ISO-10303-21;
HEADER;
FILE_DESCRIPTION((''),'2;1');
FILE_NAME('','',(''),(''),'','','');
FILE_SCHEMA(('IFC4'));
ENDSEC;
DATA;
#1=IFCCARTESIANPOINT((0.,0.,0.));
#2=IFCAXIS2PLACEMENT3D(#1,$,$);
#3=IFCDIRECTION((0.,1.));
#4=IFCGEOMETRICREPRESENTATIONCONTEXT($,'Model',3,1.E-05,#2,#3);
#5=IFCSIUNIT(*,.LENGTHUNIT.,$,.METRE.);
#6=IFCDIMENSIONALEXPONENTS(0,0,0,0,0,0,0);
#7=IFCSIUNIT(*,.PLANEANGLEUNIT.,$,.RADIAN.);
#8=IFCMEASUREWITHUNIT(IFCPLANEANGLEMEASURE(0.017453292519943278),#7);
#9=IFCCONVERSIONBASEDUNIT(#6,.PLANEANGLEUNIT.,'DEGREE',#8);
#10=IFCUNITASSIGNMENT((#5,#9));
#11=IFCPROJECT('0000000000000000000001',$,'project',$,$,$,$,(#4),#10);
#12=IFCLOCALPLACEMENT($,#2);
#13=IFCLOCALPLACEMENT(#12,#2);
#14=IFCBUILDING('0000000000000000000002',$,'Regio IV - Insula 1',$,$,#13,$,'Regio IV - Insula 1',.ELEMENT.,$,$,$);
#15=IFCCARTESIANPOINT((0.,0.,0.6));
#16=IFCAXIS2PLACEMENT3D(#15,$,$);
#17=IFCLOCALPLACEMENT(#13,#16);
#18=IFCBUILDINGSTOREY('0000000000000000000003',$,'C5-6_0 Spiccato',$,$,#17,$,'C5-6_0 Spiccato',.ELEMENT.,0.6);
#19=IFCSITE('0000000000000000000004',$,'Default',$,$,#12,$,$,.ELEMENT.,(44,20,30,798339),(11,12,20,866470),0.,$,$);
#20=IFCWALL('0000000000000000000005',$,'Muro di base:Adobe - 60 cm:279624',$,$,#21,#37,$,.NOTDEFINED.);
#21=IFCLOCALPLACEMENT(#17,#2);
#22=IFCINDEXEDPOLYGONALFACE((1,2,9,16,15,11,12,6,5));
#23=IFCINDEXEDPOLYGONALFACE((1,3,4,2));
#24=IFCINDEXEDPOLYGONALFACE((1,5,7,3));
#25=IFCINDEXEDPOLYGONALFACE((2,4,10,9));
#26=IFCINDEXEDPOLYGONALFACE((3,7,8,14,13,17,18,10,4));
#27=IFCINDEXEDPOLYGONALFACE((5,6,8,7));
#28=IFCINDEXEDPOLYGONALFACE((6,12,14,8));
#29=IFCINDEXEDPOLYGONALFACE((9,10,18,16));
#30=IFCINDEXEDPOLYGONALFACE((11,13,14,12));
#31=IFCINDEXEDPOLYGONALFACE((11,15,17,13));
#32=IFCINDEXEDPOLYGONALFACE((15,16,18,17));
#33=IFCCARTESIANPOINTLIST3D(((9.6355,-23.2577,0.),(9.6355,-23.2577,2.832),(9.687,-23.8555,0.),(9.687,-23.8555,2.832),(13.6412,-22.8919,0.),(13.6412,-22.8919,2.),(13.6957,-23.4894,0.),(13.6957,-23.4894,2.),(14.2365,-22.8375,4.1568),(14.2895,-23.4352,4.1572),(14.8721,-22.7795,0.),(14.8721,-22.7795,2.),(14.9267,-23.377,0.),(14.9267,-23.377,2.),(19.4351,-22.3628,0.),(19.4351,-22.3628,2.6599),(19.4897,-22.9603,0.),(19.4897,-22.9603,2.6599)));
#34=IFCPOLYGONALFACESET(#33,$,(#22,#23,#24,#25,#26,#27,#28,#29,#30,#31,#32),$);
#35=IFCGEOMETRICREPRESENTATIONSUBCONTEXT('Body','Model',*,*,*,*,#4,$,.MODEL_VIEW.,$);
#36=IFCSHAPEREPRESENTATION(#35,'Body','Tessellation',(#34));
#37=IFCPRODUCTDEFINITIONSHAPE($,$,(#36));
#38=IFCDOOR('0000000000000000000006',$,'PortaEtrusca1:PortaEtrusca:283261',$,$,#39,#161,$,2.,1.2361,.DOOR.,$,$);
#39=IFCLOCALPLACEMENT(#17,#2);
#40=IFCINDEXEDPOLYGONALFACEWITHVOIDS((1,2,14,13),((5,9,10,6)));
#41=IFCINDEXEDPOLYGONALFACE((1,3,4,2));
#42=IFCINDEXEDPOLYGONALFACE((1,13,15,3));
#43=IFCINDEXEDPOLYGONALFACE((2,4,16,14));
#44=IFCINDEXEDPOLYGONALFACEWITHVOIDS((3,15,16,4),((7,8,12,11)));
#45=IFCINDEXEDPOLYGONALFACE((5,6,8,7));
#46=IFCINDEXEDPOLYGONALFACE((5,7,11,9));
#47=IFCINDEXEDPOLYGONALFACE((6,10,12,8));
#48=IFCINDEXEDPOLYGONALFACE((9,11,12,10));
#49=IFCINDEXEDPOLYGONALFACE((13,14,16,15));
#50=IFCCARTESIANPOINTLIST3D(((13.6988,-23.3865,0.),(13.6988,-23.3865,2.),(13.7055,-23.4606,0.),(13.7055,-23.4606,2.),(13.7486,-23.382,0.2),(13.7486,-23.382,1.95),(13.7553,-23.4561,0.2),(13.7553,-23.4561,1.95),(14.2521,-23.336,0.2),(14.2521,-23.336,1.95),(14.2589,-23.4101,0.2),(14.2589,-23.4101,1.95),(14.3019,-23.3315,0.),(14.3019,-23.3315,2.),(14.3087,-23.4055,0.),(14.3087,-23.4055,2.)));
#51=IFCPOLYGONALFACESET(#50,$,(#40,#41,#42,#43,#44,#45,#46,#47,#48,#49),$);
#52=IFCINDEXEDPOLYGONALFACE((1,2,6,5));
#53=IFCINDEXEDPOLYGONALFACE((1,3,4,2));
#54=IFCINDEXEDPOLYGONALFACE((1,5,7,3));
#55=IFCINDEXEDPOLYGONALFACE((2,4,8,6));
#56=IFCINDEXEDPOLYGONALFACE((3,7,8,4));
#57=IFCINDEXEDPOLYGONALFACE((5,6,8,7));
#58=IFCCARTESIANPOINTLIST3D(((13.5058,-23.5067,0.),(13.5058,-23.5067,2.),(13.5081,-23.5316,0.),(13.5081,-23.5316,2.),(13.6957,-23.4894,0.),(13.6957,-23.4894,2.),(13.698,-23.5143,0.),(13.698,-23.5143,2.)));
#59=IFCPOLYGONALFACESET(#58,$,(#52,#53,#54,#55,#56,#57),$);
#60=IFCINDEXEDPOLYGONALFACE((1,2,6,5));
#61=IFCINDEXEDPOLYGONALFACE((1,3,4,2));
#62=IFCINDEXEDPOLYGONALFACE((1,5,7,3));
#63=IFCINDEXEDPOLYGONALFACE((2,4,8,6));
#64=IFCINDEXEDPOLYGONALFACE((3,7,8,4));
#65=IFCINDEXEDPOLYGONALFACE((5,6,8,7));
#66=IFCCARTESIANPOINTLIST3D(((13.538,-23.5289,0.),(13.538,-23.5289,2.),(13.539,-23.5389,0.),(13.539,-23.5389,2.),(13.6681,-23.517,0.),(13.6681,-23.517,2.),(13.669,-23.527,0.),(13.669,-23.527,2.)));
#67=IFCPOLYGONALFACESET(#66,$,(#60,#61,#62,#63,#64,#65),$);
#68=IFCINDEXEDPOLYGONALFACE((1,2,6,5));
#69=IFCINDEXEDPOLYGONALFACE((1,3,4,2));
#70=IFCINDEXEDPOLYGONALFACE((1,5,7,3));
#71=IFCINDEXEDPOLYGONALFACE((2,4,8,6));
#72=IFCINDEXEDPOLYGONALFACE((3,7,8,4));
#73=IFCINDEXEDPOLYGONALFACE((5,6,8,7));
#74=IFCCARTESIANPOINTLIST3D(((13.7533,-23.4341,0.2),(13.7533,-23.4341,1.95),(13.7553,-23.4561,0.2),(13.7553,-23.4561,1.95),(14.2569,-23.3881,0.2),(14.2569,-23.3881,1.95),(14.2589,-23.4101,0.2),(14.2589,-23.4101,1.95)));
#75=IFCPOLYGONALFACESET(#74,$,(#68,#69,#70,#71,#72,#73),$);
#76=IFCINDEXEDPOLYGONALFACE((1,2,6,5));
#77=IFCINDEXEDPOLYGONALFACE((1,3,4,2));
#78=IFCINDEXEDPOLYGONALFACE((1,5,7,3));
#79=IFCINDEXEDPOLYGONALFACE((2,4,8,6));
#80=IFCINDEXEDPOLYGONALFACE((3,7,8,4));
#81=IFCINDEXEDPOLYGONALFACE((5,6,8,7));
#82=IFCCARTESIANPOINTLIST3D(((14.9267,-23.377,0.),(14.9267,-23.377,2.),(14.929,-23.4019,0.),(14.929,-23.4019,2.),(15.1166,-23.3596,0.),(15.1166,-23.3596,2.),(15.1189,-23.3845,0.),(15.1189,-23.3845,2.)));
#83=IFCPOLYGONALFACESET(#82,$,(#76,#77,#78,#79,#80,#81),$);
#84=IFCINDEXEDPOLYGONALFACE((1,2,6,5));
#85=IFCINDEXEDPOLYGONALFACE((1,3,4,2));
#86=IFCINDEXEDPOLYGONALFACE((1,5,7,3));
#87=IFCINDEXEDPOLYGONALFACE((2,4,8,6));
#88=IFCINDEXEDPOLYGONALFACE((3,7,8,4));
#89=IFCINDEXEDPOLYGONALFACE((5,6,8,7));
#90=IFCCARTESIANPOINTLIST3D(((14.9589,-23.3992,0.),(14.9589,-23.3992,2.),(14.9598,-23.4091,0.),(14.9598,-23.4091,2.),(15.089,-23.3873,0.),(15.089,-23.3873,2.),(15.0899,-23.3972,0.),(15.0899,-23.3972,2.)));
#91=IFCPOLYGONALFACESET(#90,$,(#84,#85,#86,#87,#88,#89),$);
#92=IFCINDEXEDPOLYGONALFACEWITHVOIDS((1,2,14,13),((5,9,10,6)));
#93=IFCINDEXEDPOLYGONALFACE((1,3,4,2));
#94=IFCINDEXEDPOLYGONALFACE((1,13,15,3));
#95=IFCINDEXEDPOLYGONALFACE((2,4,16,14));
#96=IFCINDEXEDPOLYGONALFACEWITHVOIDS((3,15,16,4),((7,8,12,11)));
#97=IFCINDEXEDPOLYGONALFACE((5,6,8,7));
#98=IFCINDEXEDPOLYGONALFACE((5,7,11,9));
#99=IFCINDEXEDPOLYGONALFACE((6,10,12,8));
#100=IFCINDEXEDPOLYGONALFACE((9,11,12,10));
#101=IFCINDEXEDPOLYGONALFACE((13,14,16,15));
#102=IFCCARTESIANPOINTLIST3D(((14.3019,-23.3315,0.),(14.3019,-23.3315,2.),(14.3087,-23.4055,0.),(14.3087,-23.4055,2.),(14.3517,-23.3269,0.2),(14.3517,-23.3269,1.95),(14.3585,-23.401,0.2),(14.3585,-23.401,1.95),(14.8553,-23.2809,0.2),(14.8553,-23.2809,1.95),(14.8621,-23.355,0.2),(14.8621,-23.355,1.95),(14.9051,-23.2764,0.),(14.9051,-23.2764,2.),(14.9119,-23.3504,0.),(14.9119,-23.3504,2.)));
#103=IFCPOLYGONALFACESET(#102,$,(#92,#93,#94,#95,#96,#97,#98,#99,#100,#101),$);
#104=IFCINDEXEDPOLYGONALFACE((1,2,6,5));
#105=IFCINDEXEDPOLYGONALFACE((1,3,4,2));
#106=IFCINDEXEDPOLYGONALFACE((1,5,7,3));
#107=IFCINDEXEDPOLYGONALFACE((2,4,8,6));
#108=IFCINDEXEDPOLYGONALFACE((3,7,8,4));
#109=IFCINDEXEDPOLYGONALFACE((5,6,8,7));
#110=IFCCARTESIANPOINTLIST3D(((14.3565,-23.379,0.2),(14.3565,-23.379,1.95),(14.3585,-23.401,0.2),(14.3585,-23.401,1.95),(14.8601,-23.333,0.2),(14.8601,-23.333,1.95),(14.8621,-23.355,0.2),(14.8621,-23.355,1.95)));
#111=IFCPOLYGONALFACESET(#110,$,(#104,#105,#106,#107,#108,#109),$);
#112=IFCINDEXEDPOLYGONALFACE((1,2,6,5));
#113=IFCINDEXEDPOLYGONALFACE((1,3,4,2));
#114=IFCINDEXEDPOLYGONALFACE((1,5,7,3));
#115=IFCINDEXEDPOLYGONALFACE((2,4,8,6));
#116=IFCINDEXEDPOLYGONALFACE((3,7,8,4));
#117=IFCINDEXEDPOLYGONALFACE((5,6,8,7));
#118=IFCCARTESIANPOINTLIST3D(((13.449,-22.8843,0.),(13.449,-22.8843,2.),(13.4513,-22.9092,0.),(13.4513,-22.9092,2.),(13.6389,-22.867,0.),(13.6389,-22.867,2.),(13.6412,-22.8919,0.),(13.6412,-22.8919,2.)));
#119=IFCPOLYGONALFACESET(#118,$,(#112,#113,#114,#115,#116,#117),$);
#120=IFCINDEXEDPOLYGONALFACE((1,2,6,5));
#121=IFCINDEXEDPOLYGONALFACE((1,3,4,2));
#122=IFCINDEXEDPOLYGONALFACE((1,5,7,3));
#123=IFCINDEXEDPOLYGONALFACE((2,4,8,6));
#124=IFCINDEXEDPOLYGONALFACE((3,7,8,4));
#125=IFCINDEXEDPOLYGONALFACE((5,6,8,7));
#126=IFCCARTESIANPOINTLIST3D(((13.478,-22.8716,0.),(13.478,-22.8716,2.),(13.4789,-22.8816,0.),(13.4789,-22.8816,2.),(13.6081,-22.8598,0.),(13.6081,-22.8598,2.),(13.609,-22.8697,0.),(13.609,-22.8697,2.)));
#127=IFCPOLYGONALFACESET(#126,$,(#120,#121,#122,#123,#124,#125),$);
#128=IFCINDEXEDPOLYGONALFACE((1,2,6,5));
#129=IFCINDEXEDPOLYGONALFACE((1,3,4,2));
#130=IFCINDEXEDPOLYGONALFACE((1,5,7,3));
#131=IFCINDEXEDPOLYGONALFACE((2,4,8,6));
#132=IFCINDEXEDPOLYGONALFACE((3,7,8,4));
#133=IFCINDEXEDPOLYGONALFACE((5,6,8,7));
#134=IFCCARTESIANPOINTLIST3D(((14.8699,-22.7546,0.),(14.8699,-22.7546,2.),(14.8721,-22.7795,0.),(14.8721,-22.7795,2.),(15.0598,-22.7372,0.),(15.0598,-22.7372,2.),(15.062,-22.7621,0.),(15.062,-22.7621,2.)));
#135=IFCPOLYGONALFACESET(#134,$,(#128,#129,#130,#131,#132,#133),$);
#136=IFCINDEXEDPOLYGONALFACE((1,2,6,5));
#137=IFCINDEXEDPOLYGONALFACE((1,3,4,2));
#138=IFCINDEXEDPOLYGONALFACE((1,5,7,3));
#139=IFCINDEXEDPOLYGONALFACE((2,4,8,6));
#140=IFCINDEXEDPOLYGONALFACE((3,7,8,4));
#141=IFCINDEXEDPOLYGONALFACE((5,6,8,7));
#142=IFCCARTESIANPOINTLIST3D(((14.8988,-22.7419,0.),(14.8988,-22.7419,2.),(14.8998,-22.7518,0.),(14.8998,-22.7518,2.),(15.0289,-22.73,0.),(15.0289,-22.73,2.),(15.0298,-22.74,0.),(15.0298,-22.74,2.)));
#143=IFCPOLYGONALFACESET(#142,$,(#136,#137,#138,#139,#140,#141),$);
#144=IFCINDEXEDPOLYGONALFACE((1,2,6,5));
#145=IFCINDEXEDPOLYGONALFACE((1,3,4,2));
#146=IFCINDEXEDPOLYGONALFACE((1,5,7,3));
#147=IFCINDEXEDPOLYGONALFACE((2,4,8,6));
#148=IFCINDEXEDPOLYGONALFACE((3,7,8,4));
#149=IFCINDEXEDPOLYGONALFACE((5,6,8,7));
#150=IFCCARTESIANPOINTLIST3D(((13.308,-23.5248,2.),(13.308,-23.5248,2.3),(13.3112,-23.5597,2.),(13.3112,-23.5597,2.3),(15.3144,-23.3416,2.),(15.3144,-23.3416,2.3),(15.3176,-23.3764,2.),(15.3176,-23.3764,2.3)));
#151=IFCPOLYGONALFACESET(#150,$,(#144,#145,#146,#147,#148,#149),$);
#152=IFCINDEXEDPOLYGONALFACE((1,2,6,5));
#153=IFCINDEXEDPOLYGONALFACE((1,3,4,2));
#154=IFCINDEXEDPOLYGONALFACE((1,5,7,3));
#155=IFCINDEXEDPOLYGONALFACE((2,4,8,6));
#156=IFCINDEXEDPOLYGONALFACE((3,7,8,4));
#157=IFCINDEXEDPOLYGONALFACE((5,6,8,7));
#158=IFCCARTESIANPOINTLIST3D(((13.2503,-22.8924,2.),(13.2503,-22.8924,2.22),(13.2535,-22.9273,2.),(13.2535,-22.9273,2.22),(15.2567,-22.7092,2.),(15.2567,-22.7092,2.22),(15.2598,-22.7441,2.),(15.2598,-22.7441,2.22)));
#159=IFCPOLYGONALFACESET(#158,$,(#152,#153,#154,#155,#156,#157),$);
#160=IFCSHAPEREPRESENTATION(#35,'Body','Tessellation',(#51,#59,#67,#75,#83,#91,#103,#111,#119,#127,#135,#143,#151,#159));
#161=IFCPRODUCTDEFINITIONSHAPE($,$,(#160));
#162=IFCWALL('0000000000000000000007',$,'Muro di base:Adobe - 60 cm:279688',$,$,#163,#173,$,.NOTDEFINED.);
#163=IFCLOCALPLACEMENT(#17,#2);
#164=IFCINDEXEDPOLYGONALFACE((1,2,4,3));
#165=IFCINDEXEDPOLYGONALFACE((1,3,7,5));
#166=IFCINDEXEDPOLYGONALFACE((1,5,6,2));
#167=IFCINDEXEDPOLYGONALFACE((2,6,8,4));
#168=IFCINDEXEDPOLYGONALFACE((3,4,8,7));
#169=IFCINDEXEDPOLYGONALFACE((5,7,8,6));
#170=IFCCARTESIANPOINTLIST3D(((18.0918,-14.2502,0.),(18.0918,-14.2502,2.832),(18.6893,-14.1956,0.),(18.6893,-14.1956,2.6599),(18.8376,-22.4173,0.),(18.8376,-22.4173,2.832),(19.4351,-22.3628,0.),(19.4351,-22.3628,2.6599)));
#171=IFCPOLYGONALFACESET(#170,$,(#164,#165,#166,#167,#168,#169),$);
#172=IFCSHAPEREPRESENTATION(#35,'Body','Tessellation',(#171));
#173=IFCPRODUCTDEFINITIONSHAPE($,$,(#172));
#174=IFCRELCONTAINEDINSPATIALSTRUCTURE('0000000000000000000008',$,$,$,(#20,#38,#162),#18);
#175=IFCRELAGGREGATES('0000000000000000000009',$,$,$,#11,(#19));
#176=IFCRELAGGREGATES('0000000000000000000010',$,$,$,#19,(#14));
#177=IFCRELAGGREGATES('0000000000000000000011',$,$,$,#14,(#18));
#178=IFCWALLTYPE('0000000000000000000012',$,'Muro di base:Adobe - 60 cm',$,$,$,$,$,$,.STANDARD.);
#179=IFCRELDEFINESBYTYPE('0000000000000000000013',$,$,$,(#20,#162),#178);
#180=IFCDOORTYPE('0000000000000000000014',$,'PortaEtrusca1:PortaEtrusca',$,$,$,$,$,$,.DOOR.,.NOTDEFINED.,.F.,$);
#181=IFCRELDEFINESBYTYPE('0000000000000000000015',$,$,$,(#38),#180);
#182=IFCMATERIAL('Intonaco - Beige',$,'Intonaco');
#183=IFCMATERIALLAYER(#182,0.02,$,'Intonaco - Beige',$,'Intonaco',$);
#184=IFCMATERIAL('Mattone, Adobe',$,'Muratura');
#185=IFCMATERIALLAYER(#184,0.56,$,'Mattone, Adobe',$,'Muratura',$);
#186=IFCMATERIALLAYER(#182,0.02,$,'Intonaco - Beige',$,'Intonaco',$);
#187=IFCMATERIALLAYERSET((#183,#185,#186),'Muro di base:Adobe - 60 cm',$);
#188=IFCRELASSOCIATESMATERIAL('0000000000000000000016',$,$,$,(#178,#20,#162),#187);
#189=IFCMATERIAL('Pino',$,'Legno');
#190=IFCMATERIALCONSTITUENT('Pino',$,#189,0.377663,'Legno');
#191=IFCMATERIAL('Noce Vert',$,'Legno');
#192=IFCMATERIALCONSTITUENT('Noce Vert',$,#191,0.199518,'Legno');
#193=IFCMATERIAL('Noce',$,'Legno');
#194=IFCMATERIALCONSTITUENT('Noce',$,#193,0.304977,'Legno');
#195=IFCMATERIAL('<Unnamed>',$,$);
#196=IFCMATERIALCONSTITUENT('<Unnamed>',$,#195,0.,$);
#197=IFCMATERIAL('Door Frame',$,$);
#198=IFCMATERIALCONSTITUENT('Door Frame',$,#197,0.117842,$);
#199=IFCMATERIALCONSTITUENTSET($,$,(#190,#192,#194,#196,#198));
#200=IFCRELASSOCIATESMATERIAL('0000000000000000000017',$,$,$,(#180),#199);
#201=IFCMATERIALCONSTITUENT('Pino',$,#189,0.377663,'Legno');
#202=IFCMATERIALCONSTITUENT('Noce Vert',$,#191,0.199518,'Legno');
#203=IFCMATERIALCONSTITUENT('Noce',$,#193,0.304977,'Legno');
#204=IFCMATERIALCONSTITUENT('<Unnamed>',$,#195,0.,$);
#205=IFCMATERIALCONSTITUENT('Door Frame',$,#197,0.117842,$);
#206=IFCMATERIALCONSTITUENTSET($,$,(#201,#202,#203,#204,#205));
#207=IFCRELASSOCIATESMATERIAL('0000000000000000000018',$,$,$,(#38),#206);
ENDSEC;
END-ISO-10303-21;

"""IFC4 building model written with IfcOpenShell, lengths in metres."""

from ifc_helpers import new_model, entity, si_unit, converted_unit, direction, frame, frame_2d, origin, origin_2d_with_axis, place, context, subcontext, project, spatial, polyline, rectangle, outline, extrude, clip, bounded_halfspace, source, transform, mapped, material, layer, layer_set, layer_usage, constituent, constituent_set, type_object, type_shapes, element, fill, save


model = new_model("IFC4")

# Units and contexts
model_context = context("Model", 3, precision=1e-05, world=origin(), true_north=direction((0.0, 1.0)))
body_context = subcontext(model_context, "Body", "Model", "MODEL_VIEW")
ifc_project = project(units=[si_unit("LENGTHUNIT", "METRE"), converted_unit("PLANEANGLEUNIT", "DEGREE", entity("IfcPlaneAngleMeasure", 0.017453292519943278), si_unit("PLANEANGLEUNIT", "RADIAN"), dimensions=[0, 0, 0, 0, 0, 0, 0])], contexts=[model_context])

# Site, building, storey
site_placement = place(None, origin())
site = spatial("IfcSite", under=ifc_project, at=site_placement, Name="Default", CompositionType="ELEMENT", RefLatitude=(44, 20, 30, 798339), RefLongitude=(11, 12, 20, 866470), RefElevation=0.0)
building_placement = place(site_placement, origin())
building = spatial("IfcBuilding", under=site, at=building_placement, Name="Regio IV - Insula 1", LongName="Regio IV - Insula 1", CompositionType="ELEMENT")
storey_placement = place(building_placement, frame((0.0, 0.0, 0.6)))
storey = spatial("IfcBuildingStorey", under=building, at=storey_placement, Name="C5-6_0 Spiccato", LongName="C5-6_0 Spiccato", CompositionType="ELEMENT", Elevation=0.6)

# Shared definitions
ifc_material_1 = material(Name="Intonaco - Beige", Category="Intonaco")
ifc_layer_1 = layer(ifc_material_1, 0.02, Name="Intonaco - Beige", Category="Intonaco")
ifc_material_2 = material(Name="Mattone, Adobe", Category="Muratura")
ifc_layer_2 = layer(ifc_material_2, 0.56, Name="Mattone, Adobe", Category="Muratura")
ifc_layer_3 = layer(ifc_material_1, 0.02, Name="Intonaco - Beige", Category="Intonaco")
ifc_layer_set_1 = layer_set([ifc_layer_1, ifc_layer_2, ifc_layer_3], Name="Muro di base:Adobe - 60 cm")
wall_type_1 = type_object("IfcWallType", Name="Muro di base:Adobe - 60 cm", PredefinedType="STANDARD", material=ifc_layer_set_1)

# Wall, opening, door
ifc_layer_usage_1 = layer_usage(ifc_layer_set_1, "AXIS2", "NEGATIVE", 0.3)
wall_1_placement = place(storey_placement, frame((9.6597, -23.5567, 0.0), z_axis=(0.0, 0.0, 1.0), x_axis=(0.995856, 0.090941, 0.0)))
wall_1 = element("IfcWall", 1, at=wall_1_placement, inside=storey, type_object=wall_type_1, material=ifc_layer_usage_1, Name="Muro di base:Adobe - 60 cm:279624", PredefinedType="NOTDEFINED", context=body_context, shape_type="Clipping", body=[
    clip(clip(extrude(outline(polyline([(0.0, -0.3), (9.8434, -0.3), (9.8434, 0.3), (0.0031, 0.3), (0.0, -0.3)])), origin(), (0.0, 0.0, 1.0), 4.1572), bounded_halfspace(frame((9.8434, -0.3, 2.6599), z_axis=(0.275637, 0.0, 0.961262), x_axis=(0.0, 1.0, 0.0)), False, frame((9.8434, -0.3, 2.6599)), polyline([(0.0, 0.0), (0.0, 0.6), (-0.6, 0.6), (-5.2203, 0.6), (-5.2218, 0.0), (0.0, 0.0)]))), bounded_halfspace(frame((0.0031, 0.3, 2.832), z_axis=(-0.275634, 0.001422, 0.961262), x_axis=(-0.00516, -0.999987, 0.0)), False, frame((0.0031, 0.3, 2.832)), polyline([(0.0, 0.0), (-0.0031, -0.6), (4.6185, -0.6), (4.6201, 0.0), (0.0, 0.0)]))),
])
opening_1_placement = place(wall_1_placement, frame((4.0254, -0.3, 0.0)))
opening_1 = element("IfcOpeningElement", 2, at=opening_1_placement, cuts=wall_1, PredefinedType="OPENING", context=body_context, shape_type="SweptSolid", body=[
    extrude(rectangle(XDim=2.0, YDim=1.2361, at=frame_2d((1.0, 0.618), x_axis=(1.0, 0.0))), frame((0.0, 0.0, 0.0), z_axis=(0.0, 1.0, 0.0), x_axis=(0.0, 0.0, 1.0)), (0.0, 0.0, 1.0), 0.6),
])
ifc_material_3 = material(Name="Pino", Category="Legno")
ifc_constituent_1 = constituent(ifc_material_3, Name="Pino", Category="Legno", fraction=0.377663)
ifc_material_4 = material(Name="Noce Vert", Category="Legno")
ifc_constituent_2 = constituent(ifc_material_4, Name="Noce Vert", Category="Legno", fraction=0.199518)
ifc_material_5 = material(Name="Noce", Category="Legno")
ifc_constituent_3 = constituent(ifc_material_5, Name="Noce", Category="Legno", fraction=0.304977)
ifc_material_6 = material(Name="<Unnamed>")
ifc_constituent_4 = constituent(ifc_material_6, Name="<Unnamed>", fraction=0.0)
ifc_material_7 = material(Name="Door Frame")
ifc_constituent_5 = constituent(ifc_material_7, Name="Door Frame", fraction=0.117842)
ifc_constituent_set_1 = constituent_set(constituents=[ifc_constituent_1, ifc_constituent_2, ifc_constituent_3, ifc_constituent_4, ifc_constituent_5])
ifc_constituent_6 = constituent(ifc_material_3, Name="Pino", Category="Legno", fraction=0.377663)
ifc_constituent_7 = constituent(ifc_material_4, Name="Noce Vert", Category="Legno", fraction=0.199518)
ifc_constituent_8 = constituent(ifc_material_5, Name="Noce", Category="Legno", fraction=0.304977)
ifc_constituent_9 = constituent(ifc_material_6, Name="<Unnamed>", fraction=0.0)
ifc_constituent_10 = constituent(ifc_material_7, Name="Door Frame", fraction=0.117842)
ifc_constituent_set_2 = constituent_set(constituents=[ifc_constituent_6, ifc_constituent_7, ifc_constituent_8, ifc_constituent_9, ifc_constituent_10])
door_type_1 = type_object("IfcDoorType", Name="PortaEtrusca1:PortaEtrusca", OperationType="NOTDEFINED", ParameterTakesPrecedence=False, PredefinedType="DOOR", material=ifc_constituent_set_2)
shared_shape_1 = source(origin(), body_context, "Body", "SweptSolid", [
    extrude(outline(polyline([(-1.0, -0.3028), (1.0, -0.3028), (1.0, 0.3028), (-1.0, 0.3028), (-1.0, -0.3028)]), holes=[polyline([(-0.95, 0.2528), (0.8, 0.2528), (0.8, -0.2528), (-0.95, -0.2528), (-0.95, 0.2528)])]), frame((0.3152, 0.0278, 1.0), z_axis=(0.0, 1.0, 0.0), x_axis=(0.0, 0.0, -1.0)), (0.0, 0.0, 1.0), 0.0744),
    extrude(rectangle(XDim=0.025, YDim=0.1907, at=frame_2d((0.0, 0.0), x_axis=(1.0, 0.0))), frame((-0.0953, -0.0125, 0.0), z_axis=(0.0, 0.0, 1.0), x_axis=(0.0, 1.0, 0.0)), (0.0, 0.0, 1.0), 2.0),
    extrude(rectangle(XDim=0.01, YDim=0.1306, at=frame_2d((0.0, 0.0), x_axis=(1.0, 0.0))), frame((-0.0953, -0.03, 0.0), z_axis=(0.0, 0.0, 1.0), x_axis=(0.0, 1.0, 0.0)), (0.0, 0.0, 1.0), 2.0),
    extrude(rectangle(XDim=0.0221, YDim=0.5057, at=frame_2d((0.0, 0.0), x_axis=(1.0, 0.0))), frame((0.3152, 0.0388, 0.2), z_axis=(0.0, 0.0, 1.0), x_axis=(0.0, 1.0, 0.0)), (0.0, 0.0, 1.0), 1.75),
    extrude(rectangle(XDim=0.025, YDim=0.1907, at=frame_2d((0.0, 0.0), x_axis=(1.0, 0.0))), frame((1.3314, -0.0125, 0.0), z_axis=(0.0, 0.0, 1.0), x_axis=(0.0, 1.0, 0.0)), (0.0, 0.0, 1.0), 2.0),
    extrude(rectangle(XDim=0.01, YDim=0.1306, at=frame_2d((0.0, 0.0), x_axis=(1.0, 0.0))), frame((1.3314, -0.03, 0.0), z_axis=(0.0, 0.0, 1.0), x_axis=(0.0, 1.0, 0.0)), (0.0, 0.0, 1.0), 2.0),
    extrude(outline(polyline([(-0.3028, -1.0), (0.3028, -1.0), (0.3028, 1.0), (-0.3028, 1.0), (-0.3028, -1.0)]), holes=[polyline([(0.2528, -0.95), (-0.2528, -0.95), (-0.2528, 0.8), (0.2528, 0.8), (0.2528, -0.95)])]), frame((0.9209, 0.0278, 1.0), z_axis=(0.0, 1.0, 0.0), x_axis=(1.0, 0.0, 0.0)), (0.0, 0.0, 1.0), 0.0744),
    extrude(rectangle(XDim=0.0221, YDim=0.5057, at=frame_2d((0.0, 0.0), x_axis=(1.0, 0.0))), frame((0.9209, 0.0388, 0.2), z_axis=(0.0, 0.0, 1.0), x_axis=(0.0, 1.0, 0.0)), (0.0, 0.0, 1.0), 1.75),
    extrude(rectangle(XDim=0.025, YDim=0.1907, at=frame_2d((0.0, 0.0), x_axis=(1.0, 0.0))), frame((-0.0953, 0.6125, 0.0), z_axis=(0.0, 0.0, 1.0), x_axis=(0.0, -1.0, 0.0)), (0.0, 0.0, 1.0), 2.0),
    extrude(rectangle(XDim=0.01, YDim=0.1306, at=origin_2d_with_axis()), frame((-0.0953, 0.63, 0.0), z_axis=(0.0, 0.0, 1.0), x_axis=(0.0, -1.0, 0.0)), (0.0, 0.0, 1.0), 2.0),
    extrude(rectangle(XDim=0.025, YDim=0.1907, at=frame_2d((0.0, 0.0), x_axis=(1.0, 0.0))), frame((1.3314, 0.6125, 0.0), z_axis=(0.0, 0.0, 1.0), x_axis=(0.0, -1.0, 0.0)), (0.0, 0.0, 1.0), 2.0),
    extrude(rectangle(XDim=0.01, YDim=0.1306, at=origin_2d_with_axis()), frame((1.3314, 0.63, 0.0), z_axis=(0.0, 0.0, 1.0), x_axis=(0.0, -1.0, 0.0)), (0.0, 0.0, 1.0), 2.0),
    extrude(rectangle(XDim=0.035, YDim=2.0147, at=frame_2d((0.0, 0.0), x_axis=(1.0, 0.0))), frame((0.618, -0.0175, 2.0), z_axis=(0.0, 0.0, 1.0), x_axis=(0.0, 1.0, 0.0)), (0.0, 0.0, 1.0), 0.3),
    extrude(rectangle(XDim=0.035, YDim=2.0147, at=frame_2d((0.0, 0.0), x_axis=(1.0, 0.0))), frame((0.618, 0.6175, 2.0), z_axis=(0.0, 0.0, 1.0), x_axis=(0.0, -1.0, 0.0)), (0.0, 0.0, 1.0), 0.22),
])
type_shapes(door_type_1, [shared_shape_1])
door_1_placement = place(opening_1_placement, origin())
door_1 = element("IfcDoor", 3, at=door_1_placement, inside=storey, type_object=door_type_1, material=ifc_constituent_set_1, Name="PortaEtrusca1:PortaEtrusca:283261", OverallHeight=2.0, OverallWidth=1.2361, PredefinedType="DOOR", context=body_context, shape_type="MappedRepresentation", body=[
    mapped(shared_shape_1, transform((0.0, 0.0, 0.0), scale=1.0)),
])
fill(opening_1, door_1)

# Wall
ifc_layer_usage_2 = layer_usage(ifc_layer_set_1, "AXIS2", "NEGATIVE", 0.3)
wall_2_placement = place(storey_placement, frame((19.1364, -22.3901, 0.0), z_axis=(0.0, 0.0, 1.0), x_axis=(-0.090941, 0.995856, 0.0)))
element("IfcWall", 4, at=wall_2_placement, inside=storey, type_object=wall_type_1, material=ifc_layer_usage_2, Name="Muro di base:Adobe - 60 cm:279688", PredefinedType="NOTDEFINED", context=body_context, shape_type="Clipping", body=[
    clip(extrude(rectangle(XDim=8.2011, YDim=0.6, at=frame_2d((4.1006, 0.0), x_axis=(-1.0, 0.0))), origin(), (0.0, 0.0, 1.0), 2.832), bounded_halfspace(frame((0.0, -0.3, 2.6599), z_axis=(0.0, -0.275637, 0.961262), x_axis=(1.0, 0.0, 0.0)), False, frame((0.0, -0.3, 2.6599)), polyline([(0.0, 0.0), (8.2011, 0.0), (8.2011, 0.6), (0.0, 0.6), (0.0, 0.0)]))),
])

save(model, "model.ifc")
